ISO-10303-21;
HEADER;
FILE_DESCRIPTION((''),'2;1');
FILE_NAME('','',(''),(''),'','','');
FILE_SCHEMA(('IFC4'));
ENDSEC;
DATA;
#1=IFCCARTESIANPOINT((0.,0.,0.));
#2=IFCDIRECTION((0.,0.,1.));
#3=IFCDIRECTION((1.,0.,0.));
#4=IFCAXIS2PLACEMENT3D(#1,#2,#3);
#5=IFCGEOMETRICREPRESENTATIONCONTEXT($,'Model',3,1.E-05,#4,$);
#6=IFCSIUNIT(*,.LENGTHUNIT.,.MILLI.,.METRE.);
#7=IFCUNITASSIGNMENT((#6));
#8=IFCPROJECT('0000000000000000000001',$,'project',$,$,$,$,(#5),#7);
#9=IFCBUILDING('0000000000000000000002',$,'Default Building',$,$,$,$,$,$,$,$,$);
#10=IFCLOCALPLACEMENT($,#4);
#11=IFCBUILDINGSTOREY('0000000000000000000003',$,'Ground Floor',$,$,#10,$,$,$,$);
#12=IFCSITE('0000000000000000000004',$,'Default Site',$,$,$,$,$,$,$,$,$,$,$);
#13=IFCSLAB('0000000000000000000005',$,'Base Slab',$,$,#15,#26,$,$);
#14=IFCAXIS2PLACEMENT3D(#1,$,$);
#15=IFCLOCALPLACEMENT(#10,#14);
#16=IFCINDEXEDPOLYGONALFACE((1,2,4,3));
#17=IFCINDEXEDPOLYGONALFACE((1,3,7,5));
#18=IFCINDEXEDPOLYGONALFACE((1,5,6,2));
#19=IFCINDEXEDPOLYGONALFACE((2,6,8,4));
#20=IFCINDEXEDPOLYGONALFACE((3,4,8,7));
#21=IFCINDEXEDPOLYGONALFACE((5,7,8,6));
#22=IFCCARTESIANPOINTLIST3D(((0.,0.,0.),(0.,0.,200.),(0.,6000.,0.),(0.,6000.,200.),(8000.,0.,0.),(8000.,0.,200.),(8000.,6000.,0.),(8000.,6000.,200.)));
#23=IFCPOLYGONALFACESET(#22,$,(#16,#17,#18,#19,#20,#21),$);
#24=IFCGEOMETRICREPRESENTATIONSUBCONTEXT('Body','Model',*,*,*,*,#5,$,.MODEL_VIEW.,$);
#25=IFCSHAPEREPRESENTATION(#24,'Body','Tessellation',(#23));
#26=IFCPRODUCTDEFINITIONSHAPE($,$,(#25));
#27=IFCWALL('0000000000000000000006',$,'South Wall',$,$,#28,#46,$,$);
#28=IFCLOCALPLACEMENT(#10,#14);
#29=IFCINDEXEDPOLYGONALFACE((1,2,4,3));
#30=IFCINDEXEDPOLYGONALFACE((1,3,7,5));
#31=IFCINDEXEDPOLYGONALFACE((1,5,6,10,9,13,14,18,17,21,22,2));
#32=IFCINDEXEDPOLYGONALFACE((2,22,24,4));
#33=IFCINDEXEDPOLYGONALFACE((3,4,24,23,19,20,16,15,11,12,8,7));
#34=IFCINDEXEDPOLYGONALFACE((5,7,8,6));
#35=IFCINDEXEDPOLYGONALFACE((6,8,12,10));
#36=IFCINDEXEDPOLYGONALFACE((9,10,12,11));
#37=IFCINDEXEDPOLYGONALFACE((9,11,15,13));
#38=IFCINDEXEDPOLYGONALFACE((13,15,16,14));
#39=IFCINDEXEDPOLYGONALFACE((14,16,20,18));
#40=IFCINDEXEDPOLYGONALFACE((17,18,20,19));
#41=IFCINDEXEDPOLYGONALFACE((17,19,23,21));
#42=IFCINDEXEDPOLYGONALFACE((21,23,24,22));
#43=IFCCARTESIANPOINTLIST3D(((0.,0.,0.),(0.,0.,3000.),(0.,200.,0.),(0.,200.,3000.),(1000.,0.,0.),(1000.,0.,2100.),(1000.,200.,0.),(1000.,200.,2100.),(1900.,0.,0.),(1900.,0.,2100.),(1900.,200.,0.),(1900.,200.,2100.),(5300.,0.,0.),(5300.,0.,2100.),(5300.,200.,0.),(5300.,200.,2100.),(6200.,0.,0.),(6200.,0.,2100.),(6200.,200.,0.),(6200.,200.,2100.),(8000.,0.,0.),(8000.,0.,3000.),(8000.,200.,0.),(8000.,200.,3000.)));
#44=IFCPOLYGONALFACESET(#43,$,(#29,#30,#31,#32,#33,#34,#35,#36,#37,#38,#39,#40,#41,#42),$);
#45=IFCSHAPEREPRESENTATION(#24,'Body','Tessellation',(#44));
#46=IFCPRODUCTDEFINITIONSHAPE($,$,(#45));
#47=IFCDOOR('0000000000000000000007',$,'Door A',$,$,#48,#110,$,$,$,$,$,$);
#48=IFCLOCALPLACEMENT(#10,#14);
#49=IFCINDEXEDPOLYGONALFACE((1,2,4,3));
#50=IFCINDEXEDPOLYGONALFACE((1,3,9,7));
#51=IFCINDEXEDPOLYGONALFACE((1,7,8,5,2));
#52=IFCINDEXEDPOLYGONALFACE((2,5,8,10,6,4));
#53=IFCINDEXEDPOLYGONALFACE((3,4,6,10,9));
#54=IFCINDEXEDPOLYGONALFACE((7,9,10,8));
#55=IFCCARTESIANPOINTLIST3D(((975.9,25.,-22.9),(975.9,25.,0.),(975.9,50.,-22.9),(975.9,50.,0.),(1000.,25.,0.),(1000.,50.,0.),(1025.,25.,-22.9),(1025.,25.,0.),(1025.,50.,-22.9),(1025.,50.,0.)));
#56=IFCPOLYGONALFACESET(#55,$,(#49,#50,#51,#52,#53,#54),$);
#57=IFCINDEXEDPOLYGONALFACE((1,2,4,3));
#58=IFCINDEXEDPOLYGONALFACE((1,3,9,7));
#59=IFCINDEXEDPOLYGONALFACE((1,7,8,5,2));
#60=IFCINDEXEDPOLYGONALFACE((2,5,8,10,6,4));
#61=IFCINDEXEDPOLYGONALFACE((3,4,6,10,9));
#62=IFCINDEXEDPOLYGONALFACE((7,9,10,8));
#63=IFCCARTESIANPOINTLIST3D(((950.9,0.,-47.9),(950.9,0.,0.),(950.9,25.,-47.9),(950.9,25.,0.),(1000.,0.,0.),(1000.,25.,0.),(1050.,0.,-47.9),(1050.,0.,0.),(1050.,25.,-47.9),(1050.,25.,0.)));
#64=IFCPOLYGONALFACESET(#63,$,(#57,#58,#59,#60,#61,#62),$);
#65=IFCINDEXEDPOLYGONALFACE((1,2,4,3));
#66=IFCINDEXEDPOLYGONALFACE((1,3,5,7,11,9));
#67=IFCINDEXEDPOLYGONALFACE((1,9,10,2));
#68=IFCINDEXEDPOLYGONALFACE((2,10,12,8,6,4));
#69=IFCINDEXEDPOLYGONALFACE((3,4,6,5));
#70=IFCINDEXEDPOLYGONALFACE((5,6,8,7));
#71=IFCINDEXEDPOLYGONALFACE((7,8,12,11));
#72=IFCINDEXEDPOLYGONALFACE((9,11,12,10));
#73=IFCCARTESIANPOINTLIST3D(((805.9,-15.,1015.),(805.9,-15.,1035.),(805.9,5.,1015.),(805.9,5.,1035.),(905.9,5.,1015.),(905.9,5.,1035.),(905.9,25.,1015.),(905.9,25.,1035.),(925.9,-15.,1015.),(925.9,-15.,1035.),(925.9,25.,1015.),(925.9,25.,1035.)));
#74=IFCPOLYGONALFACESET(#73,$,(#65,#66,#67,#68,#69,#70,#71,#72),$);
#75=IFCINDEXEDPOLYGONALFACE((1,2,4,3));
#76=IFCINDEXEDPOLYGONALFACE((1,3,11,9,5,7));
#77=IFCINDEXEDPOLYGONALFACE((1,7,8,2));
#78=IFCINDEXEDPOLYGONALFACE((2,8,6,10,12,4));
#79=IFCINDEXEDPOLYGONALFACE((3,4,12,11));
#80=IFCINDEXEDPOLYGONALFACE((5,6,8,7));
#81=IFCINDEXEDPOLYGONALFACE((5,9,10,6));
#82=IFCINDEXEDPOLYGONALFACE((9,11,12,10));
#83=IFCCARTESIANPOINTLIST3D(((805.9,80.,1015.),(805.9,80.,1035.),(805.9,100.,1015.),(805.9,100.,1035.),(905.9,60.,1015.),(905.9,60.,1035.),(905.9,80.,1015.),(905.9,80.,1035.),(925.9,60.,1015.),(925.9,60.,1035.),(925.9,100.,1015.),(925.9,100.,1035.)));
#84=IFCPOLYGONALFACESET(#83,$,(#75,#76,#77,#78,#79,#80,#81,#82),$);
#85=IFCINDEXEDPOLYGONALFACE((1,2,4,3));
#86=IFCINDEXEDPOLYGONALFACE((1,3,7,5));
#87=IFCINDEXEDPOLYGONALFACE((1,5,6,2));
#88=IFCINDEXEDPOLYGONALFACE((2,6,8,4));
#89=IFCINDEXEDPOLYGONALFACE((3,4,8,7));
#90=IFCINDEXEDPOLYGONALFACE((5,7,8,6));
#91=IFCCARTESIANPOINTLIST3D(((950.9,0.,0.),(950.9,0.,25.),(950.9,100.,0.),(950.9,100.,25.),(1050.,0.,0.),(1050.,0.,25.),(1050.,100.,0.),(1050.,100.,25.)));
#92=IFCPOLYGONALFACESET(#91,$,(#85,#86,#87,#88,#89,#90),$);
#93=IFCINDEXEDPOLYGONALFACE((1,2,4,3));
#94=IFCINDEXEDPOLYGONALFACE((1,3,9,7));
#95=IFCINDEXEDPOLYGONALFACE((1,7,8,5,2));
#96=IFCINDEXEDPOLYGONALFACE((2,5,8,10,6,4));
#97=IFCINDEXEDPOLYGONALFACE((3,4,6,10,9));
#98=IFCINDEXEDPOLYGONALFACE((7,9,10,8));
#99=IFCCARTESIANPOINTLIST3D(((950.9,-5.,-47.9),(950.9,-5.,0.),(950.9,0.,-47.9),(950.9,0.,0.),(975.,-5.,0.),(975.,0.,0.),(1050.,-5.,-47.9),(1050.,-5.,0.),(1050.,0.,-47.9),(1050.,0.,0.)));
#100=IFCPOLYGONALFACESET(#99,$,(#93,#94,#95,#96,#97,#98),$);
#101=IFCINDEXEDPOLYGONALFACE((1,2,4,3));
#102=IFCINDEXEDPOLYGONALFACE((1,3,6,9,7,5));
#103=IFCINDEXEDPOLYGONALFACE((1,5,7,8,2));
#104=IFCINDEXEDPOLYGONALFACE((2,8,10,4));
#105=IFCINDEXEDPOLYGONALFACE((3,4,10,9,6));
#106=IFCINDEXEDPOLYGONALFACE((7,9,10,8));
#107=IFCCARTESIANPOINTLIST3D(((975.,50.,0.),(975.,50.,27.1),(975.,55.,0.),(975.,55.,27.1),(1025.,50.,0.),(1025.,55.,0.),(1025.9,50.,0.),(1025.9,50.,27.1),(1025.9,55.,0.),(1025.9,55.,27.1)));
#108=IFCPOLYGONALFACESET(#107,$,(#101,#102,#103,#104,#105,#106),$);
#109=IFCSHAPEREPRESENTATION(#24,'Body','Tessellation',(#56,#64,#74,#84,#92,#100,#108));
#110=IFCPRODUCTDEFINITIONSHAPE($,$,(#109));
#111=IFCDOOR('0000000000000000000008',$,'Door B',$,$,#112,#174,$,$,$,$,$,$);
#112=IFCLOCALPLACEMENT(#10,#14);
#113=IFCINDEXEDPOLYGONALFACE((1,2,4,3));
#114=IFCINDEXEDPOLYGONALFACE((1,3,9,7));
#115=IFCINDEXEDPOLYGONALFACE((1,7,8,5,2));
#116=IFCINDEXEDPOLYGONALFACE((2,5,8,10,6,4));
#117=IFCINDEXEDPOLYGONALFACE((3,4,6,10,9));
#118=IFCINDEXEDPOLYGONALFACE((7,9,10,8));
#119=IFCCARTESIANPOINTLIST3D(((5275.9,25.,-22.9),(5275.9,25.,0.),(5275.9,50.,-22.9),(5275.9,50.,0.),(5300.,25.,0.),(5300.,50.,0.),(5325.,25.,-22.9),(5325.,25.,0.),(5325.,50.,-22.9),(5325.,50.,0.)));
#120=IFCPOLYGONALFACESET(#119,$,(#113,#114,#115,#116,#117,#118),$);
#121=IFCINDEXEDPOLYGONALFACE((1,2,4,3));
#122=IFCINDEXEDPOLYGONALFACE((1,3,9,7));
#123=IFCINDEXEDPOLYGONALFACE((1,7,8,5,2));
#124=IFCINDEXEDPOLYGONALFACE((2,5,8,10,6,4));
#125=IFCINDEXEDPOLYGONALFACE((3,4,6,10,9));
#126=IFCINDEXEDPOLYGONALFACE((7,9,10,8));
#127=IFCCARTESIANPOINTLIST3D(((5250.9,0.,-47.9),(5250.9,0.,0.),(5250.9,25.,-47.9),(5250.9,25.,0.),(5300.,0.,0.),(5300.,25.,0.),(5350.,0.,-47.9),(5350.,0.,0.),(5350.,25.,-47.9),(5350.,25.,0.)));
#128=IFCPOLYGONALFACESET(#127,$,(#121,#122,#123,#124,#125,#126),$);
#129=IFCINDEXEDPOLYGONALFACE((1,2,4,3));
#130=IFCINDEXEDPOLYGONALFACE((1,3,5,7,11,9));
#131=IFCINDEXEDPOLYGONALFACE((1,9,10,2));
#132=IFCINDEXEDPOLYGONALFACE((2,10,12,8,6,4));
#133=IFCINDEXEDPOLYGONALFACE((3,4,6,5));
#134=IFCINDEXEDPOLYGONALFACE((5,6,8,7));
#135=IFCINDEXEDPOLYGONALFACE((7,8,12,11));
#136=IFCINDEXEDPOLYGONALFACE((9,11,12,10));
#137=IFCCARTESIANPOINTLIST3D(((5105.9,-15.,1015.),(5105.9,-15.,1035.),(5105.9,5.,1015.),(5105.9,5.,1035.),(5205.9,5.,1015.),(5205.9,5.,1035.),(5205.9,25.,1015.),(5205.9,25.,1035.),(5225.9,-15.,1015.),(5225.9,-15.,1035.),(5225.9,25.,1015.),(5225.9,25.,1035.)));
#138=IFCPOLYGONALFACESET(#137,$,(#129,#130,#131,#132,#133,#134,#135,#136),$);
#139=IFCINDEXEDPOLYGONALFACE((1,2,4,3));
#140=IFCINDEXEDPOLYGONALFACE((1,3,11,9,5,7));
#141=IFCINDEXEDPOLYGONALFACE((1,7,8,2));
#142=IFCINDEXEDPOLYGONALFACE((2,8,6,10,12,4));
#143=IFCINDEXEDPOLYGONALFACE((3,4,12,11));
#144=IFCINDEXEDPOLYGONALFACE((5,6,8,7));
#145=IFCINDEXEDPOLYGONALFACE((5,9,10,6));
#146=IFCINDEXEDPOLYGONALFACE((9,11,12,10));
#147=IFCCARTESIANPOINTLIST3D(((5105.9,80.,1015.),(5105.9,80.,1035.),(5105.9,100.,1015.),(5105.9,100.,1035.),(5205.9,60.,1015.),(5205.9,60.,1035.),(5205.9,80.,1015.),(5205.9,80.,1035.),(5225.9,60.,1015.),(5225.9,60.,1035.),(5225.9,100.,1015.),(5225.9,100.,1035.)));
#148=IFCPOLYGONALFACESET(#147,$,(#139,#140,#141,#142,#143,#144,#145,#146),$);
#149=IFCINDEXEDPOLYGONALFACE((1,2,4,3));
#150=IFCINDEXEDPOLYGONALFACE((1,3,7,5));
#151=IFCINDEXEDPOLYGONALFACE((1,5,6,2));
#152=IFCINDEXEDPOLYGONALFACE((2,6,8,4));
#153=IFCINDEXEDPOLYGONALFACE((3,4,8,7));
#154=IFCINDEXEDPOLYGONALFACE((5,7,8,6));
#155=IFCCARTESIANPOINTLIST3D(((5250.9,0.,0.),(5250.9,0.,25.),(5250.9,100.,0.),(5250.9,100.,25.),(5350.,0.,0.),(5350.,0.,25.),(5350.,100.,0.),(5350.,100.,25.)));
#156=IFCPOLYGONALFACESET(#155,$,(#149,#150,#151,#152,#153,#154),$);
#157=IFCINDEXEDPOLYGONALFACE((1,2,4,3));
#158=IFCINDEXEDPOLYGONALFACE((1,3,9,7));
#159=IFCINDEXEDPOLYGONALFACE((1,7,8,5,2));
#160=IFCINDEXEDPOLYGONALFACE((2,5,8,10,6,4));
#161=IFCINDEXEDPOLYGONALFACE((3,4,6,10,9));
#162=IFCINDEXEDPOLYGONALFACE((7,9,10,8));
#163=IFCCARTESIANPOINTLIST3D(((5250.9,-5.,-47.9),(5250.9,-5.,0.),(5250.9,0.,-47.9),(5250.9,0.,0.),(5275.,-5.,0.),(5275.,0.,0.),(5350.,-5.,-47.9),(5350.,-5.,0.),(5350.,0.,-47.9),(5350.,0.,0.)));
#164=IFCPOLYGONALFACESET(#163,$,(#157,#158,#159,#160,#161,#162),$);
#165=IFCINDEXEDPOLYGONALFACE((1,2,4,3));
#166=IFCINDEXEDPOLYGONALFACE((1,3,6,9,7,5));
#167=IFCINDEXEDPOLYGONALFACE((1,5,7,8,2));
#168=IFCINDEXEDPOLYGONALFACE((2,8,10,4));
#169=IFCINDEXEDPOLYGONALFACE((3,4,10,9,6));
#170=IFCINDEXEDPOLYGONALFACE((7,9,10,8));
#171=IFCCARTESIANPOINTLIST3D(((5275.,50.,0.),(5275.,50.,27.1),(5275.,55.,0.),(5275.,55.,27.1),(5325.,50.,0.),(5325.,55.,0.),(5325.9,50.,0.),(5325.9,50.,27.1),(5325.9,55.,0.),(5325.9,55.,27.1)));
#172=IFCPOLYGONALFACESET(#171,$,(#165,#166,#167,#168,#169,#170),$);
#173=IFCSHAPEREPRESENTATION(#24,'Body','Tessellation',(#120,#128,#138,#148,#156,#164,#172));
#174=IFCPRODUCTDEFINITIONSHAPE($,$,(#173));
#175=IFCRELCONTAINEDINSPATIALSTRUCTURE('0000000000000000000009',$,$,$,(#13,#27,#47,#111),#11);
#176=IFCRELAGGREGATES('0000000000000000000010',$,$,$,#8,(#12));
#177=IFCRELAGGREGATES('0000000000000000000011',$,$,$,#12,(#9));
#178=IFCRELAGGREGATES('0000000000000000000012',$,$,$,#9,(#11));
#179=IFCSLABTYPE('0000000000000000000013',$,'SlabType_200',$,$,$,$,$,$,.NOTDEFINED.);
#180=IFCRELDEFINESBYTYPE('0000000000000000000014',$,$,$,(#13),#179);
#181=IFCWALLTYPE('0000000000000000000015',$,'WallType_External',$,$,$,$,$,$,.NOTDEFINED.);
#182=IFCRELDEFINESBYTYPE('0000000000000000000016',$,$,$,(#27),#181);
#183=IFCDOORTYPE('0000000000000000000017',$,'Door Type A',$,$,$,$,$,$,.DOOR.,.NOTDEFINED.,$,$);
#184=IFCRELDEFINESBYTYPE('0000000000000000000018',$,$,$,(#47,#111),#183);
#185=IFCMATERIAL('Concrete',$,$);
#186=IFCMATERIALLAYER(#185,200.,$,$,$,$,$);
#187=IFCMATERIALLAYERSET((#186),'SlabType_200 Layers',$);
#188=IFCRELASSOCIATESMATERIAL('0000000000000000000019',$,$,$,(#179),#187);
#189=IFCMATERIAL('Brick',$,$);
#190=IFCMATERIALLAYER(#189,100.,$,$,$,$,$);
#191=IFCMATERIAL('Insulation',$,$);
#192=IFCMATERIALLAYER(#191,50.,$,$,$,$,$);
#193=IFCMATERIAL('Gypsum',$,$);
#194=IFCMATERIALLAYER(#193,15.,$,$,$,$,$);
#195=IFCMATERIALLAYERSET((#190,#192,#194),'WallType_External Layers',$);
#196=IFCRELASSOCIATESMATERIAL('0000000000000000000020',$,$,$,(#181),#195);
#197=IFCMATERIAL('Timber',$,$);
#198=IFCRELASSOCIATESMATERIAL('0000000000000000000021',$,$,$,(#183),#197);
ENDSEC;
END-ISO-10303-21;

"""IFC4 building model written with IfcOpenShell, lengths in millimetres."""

from ifc_helpers import new_model, si_unit, frame, origin_with_axes, place, context, subcontext, project, spatial, line, indexed_curve, outline, extrude, material, layer, layer_set, type_object, element, fill, save


model = new_model("IFC4")

# Units and contexts
model_context = context("Model", 3, precision=1e-05, world=origin_with_axes())
body_context = subcontext(model_context, "Body", "Model", "MODEL_VIEW")
ifc_project = project(units=[si_unit("LENGTHUNIT", "METRE", prefix="MILLI")], contexts=[model_context])

# Site, building, storey
site = spatial("IfcSite", under=ifc_project, Name="Default Site")
building = spatial("IfcBuilding", under=site, Name="Default Building")
storey_placement = place(None, origin_with_axes())
storey = spatial("IfcBuildingStorey", under=building, at=storey_placement, Name="Ground Floor")

# Slab
ifc_material_1 = material(Name="Concrete")
ifc_layer_1 = layer(ifc_material_1, 200.0)
ifc_layer_set_1 = layer_set([ifc_layer_1], Name="SlabType_200 Layers")
slab_type = type_object("IfcSlabType", Name="SlabType_200", PredefinedType="NOTDEFINED", material=ifc_layer_set_1)
slab_placement = place(storey_placement, origin_with_axes())
element("IfcSlab", 1, at=slab_placement, inside=storey, type_object=slab_type, Name="Base Slab", context=body_context, shape_type="SweptSolid", body=[
    extrude(outline(indexed_curve([(0.0, 0.0), (8000.0, 0.0), (8000.0, 6000.0), (0.0, 6000.0), (0.0, 0.0)])), None, (0.0, 0.0, 1.0), 200.0),
])

# Wall, openings, doors
ifc_material_2 = material(Name="Brick")
ifc_layer_2 = layer(ifc_material_2, 100.0)
ifc_material_3 = material(Name="Insulation")
ifc_layer_3 = layer(ifc_material_3, 50.0)
ifc_material_4 = material(Name="Gypsum")
ifc_layer_4 = layer(ifc_material_4, 15.0)
ifc_layer_set_2 = layer_set([ifc_layer_2, ifc_layer_3, ifc_layer_4], Name="WallType_External Layers")
wall_type = type_object("IfcWallType", Name="WallType_External", PredefinedType="NOTDEFINED", material=ifc_layer_set_2)
wall_1_placement = place(storey_placement, origin_with_axes())
wall_1 = element("IfcWall", 2, at=wall_1_placement, inside=storey, type_object=wall_type, Name="South Wall", context=body_context, shape_type="SweptSolid", body=[
    extrude(outline(indexed_curve([(0.0, 0.0), (8000.0, 0.0), (8000.0, 200.0), (0.0, 200.0), (0.0, 0.0)])), None, (0.0, 0.0, 1.0), 3000.0),
])
opening_1_placement = place(wall_1_placement, origin_with_axes())
opening_1 = element("IfcOpeningElement", 3, at=opening_1_placement, cuts=wall_1, context=body_context, shape_type="SweptSolid", body=[
    extrude(outline(indexed_curve([(1000.0, 0.0), (1900.0, 0.0), (1900.0, 200.0), (1000.0, 200.0), (1000.0, 0.0)])), None, (0.0, 0.0, 1.0), 2100.0),
])
opening_2_placement = place(wall_1_placement, origin_with_axes())
opening_2 = element("IfcOpeningElement", 4, at=opening_2_placement, cuts=wall_1, context=body_context, shape_type="SweptSolid", body=[
    extrude(outline(indexed_curve([(5300.0, 0.0), (6200.0, 0.0), (6200.0, 200.0), (5300.0, 200.0), (5300.0, 0.0)])), None, (0.0, 0.0, 1.0), 2100.0),
])
ifc_material_5 = material(Name="Timber")
door_type = type_object("IfcDoorType", Name="Door Type A", OperationType="NOTDEFINED", PredefinedType="DOOR", material=ifc_material_5)
door_1_placement = place(storey_placement, frame((1000.0, 0.0, 0.0), z_axis=(0.0, 0.0, 1.0), x_axis=(1.0, 0.0, 0.0)))
door_1 = element("IfcDoor", 5, at=door_1_placement, inside=storey, type_object=door_type, Name="Door A", context=body_context, shape_type="SweptSolid", body=[
    extrude(outline(indexed_curve([(0.0, 0.0), (0.0, 2.1), (0.9, 2.1), (0.9, 0.0), (-24.1, 0.0), (-24.1, -22.9), (25.0, -22.9), (25.0, 0.0)], segments=[line(1, 2, 3, 4, 5, 6, 7, 8, 1)])), frame((0.0, 25.0, 0.0), z_axis=(0.0, -1.0, 0.0), x_axis=(1.0, 0.0, 0.0)), (0.0, 0.0, -1.0), 25.0),
    extrude(outline(indexed_curve([(0.0, 0.0), (0.0, 2.1), (0.9, 2.1), (0.9, 0.0), (-49.1, 0.0), (-49.1, -47.9), (50.0, -47.9), (50.0, 0.0)], segments=[line(1, 2, 3, 4, 5, 6, 7, 8, 1)])), frame((0.0, 0.0, 0.0), z_axis=(0.0, -1.0, 0.0), x_axis=(1.0, 0.0, 0.0)), (0.0, 0.0, -1.0), 25.0),
    extrude(outline(indexed_curve([(0.0, 0.0), (-49.1, 0.0), (-49.1, 35.0), (0.0, 35.0)], segments=[line(1, 2, 3, 4, 1)])), frame((25.0, 25.0, 25.0), z_axis=(0.0, 0.0, 1.0), x_axis=(1.0, 0.0, 0.0)), (0.0, 0.0, 1.0), -47.9),
    extrude(outline(indexed_curve([(0.0, 0.0), (0.0, -40.0), (-120.0, -40.0), (-120.0, -20.0), (-20.0, -20.0), (-20.0, 0.0)], segments=[line(1, 2, 3, 4, 5, 6, 1)])), frame((-74.1, 25.0, 1015.0), z_axis=(0.0, 0.0, 1.0), x_axis=(1.0, 0.0, 0.0)), (0.0, 0.0, 1.0), 20.0),
    extrude(outline(indexed_curve([(0.0, 0.0), (0.0, 40.0), (-120.0, 40.0), (-120.0, 20.0), (-20.0, 20.0), (-20.0, 0.0)], segments=[line(1, 2, 3, 4, 5, 6, 1)])), frame((-74.1, 60.0, 1015.0), z_axis=(0.0, 0.0, 1.0), x_axis=(1.0, 0.0, 0.0)), (0.0, 0.0, 1.0), 20.0),
    extrude(outline(indexed_curve([(0.0, 0.0), (-99.1, 0.0), (-99.1, 100.0), (0.0, 100.0)], segments=[line(1, 2, 3, 4, 1)])), frame((50.0, 0.0, 0.0), z_axis=(0.0, 0.0, 1.0), x_axis=(1.0, 0.0, 0.0)), (0.0, 0.0, 1.0), 25.0),
    extrude(outline(indexed_curve([(0.0, 0.0), (0.0, 27.1), (50.9, 27.1), (50.9, 0.0), (-24.1, 0.0), (-24.1, -47.9), (75.0, -47.9), (75.0, 0.0)], segments=[line(1, 2, 3, 4, 5, 6, 7, 8, 1)])), frame((-25.0, -5.0, 0.0), z_axis=(0.0, -1.0, 0.0), x_axis=(1.0, 0.0, 0.0)), (0.0, 0.0, -1.0), 5.0),
    extrude(outline(indexed_curve([(0.0, 0.0), (0.0, 27.1), (50.9, 27.1), (50.9, 0.0), (0.9, 0.0), (0.9, -22.9), (50.0, -22.9), (50.0, 0.0)], segments=[line(1, 2, 3, 4, 5, 6, 7, 8, 1)])), frame((-25.0, 50.0, 0.0), z_axis=(0.0, -1.0, 0.0), x_axis=(1.0, 0.0, 0.0)), (0.0, 0.0, -1.0), 5.0),
])
fill(opening_1, door_1)
door_2_placement = place(storey_placement, frame((5300.0, 0.0, 0.0), z_axis=(0.0, 0.0, 1.0), x_axis=(1.0, 0.0, 0.0)))
door_2 = element("IfcDoor", 6, at=door_2_placement, inside=storey, type_object=door_type, Name="Door B", context=body_context, shape_type="SweptSolid", body=[
    extrude(outline(indexed_curve([(0.0, 0.0), (0.0, 2.1), (0.9, 2.1), (0.9, 0.0), (-24.1, 0.0), (-24.1, -22.9), (25.0, -22.9), (25.0, 0.0)], segments=[line(1, 2, 3, 4, 5, 6, 7, 8, 1)])), frame((0.0, 25.0, 0.0), z_axis=(0.0, -1.0, 0.0), x_axis=(1.0, 0.0, 0.0)), (0.0, 0.0, -1.0), 25.0),
    extrude(outline(indexed_curve([(0.0, 0.0), (0.0, 2.1), (0.9, 2.1), (0.9, 0.0), (-49.1, 0.0), (-49.1, -47.9), (50.0, -47.9), (50.0, 0.0)], segments=[line(1, 2, 3, 4, 5, 6, 7, 8, 1)])), frame((0.0, 0.0, 0.0), z_axis=(0.0, -1.0, 0.0), x_axis=(1.0, 0.0, 0.0)), (0.0, 0.0, -1.0), 25.0),
    extrude(outline(indexed_curve([(0.0, 0.0), (-49.1, 0.0), (-49.1, 35.0), (0.0, 35.0)], segments=[line(1, 2, 3, 4, 1)])), frame((25.0, 25.0, 25.0), z_axis=(0.0, 0.0, 1.0), x_axis=(1.0, 0.0, 0.0)), (0.0, 0.0, 1.0), -47.9),
    extrude(outline(indexed_curve([(0.0, 0.0), (0.0, -40.0), (-120.0, -40.0), (-120.0, -20.0), (-20.0, -20.0), (-20.0, 0.0)], segments=[line(1, 2, 3, 4, 5, 6, 1)])), frame((-74.1, 25.0, 1015.0), z_axis=(0.0, 0.0, 1.0), x_axis=(1.0, 0.0, 0.0)), (0.0, 0.0, 1.0), 20.0),
    extrude(outline(indexed_curve([(0.0, 0.0), (0.0, 40.0), (-120.0, 40.0), (-120.0, 20.0), (-20.0, 20.0), (-20.0, 0.0)], segments=[line(1, 2, 3, 4, 5, 6, 1)])), frame((-74.1, 60.0, 1015.0), z_axis=(0.0, 0.0, 1.0), x_axis=(1.0, 0.0, 0.0)), (0.0, 0.0, 1.0), 20.0),
    extrude(outline(indexed_curve([(0.0, 0.0), (-99.1, 0.0), (-99.1, 100.0), (0.0, 100.0)], segments=[line(1, 2, 3, 4, 1)])), frame((50.0, 0.0, 0.0), z_axis=(0.0, 0.0, 1.0), x_axis=(1.0, 0.0, 0.0)), (0.0, 0.0, 1.0), 25.0),
    extrude(outline(indexed_curve([(0.0, 0.0), (0.0, 27.1), (50.9, 27.1), (50.9, 0.0), (-24.1, 0.0), (-24.1, -47.9), (75.0, -47.9), (75.0, 0.0)], segments=[line(1, 2, 3, 4, 5, 6, 7, 8, 1)])), frame((-25.0, -5.0, 0.0), z_axis=(0.0, -1.0, 0.0), x_axis=(1.0, 0.0, 0.0)), (0.0, 0.0, -1.0), 5.0),
    extrude(outline(indexed_curve([(0.0, 0.0), (0.0, 27.1), (50.9, 27.1), (50.9, 0.0), (0.9, 0.0), (0.9, -22.9), (50.0, -22.9), (50.0, 0.0)], segments=[line(1, 2, 3, 4, 5, 6, 7, 8, 1)])), frame((-25.0, 50.0, 0.0), z_axis=(0.0, -1.0, 0.0), x_axis=(1.0, 0.0, 0.0)), (0.0, 0.0, -1.0), 5.0),
])
fill(opening_2, door_2)

save(model, "model.ifc")
